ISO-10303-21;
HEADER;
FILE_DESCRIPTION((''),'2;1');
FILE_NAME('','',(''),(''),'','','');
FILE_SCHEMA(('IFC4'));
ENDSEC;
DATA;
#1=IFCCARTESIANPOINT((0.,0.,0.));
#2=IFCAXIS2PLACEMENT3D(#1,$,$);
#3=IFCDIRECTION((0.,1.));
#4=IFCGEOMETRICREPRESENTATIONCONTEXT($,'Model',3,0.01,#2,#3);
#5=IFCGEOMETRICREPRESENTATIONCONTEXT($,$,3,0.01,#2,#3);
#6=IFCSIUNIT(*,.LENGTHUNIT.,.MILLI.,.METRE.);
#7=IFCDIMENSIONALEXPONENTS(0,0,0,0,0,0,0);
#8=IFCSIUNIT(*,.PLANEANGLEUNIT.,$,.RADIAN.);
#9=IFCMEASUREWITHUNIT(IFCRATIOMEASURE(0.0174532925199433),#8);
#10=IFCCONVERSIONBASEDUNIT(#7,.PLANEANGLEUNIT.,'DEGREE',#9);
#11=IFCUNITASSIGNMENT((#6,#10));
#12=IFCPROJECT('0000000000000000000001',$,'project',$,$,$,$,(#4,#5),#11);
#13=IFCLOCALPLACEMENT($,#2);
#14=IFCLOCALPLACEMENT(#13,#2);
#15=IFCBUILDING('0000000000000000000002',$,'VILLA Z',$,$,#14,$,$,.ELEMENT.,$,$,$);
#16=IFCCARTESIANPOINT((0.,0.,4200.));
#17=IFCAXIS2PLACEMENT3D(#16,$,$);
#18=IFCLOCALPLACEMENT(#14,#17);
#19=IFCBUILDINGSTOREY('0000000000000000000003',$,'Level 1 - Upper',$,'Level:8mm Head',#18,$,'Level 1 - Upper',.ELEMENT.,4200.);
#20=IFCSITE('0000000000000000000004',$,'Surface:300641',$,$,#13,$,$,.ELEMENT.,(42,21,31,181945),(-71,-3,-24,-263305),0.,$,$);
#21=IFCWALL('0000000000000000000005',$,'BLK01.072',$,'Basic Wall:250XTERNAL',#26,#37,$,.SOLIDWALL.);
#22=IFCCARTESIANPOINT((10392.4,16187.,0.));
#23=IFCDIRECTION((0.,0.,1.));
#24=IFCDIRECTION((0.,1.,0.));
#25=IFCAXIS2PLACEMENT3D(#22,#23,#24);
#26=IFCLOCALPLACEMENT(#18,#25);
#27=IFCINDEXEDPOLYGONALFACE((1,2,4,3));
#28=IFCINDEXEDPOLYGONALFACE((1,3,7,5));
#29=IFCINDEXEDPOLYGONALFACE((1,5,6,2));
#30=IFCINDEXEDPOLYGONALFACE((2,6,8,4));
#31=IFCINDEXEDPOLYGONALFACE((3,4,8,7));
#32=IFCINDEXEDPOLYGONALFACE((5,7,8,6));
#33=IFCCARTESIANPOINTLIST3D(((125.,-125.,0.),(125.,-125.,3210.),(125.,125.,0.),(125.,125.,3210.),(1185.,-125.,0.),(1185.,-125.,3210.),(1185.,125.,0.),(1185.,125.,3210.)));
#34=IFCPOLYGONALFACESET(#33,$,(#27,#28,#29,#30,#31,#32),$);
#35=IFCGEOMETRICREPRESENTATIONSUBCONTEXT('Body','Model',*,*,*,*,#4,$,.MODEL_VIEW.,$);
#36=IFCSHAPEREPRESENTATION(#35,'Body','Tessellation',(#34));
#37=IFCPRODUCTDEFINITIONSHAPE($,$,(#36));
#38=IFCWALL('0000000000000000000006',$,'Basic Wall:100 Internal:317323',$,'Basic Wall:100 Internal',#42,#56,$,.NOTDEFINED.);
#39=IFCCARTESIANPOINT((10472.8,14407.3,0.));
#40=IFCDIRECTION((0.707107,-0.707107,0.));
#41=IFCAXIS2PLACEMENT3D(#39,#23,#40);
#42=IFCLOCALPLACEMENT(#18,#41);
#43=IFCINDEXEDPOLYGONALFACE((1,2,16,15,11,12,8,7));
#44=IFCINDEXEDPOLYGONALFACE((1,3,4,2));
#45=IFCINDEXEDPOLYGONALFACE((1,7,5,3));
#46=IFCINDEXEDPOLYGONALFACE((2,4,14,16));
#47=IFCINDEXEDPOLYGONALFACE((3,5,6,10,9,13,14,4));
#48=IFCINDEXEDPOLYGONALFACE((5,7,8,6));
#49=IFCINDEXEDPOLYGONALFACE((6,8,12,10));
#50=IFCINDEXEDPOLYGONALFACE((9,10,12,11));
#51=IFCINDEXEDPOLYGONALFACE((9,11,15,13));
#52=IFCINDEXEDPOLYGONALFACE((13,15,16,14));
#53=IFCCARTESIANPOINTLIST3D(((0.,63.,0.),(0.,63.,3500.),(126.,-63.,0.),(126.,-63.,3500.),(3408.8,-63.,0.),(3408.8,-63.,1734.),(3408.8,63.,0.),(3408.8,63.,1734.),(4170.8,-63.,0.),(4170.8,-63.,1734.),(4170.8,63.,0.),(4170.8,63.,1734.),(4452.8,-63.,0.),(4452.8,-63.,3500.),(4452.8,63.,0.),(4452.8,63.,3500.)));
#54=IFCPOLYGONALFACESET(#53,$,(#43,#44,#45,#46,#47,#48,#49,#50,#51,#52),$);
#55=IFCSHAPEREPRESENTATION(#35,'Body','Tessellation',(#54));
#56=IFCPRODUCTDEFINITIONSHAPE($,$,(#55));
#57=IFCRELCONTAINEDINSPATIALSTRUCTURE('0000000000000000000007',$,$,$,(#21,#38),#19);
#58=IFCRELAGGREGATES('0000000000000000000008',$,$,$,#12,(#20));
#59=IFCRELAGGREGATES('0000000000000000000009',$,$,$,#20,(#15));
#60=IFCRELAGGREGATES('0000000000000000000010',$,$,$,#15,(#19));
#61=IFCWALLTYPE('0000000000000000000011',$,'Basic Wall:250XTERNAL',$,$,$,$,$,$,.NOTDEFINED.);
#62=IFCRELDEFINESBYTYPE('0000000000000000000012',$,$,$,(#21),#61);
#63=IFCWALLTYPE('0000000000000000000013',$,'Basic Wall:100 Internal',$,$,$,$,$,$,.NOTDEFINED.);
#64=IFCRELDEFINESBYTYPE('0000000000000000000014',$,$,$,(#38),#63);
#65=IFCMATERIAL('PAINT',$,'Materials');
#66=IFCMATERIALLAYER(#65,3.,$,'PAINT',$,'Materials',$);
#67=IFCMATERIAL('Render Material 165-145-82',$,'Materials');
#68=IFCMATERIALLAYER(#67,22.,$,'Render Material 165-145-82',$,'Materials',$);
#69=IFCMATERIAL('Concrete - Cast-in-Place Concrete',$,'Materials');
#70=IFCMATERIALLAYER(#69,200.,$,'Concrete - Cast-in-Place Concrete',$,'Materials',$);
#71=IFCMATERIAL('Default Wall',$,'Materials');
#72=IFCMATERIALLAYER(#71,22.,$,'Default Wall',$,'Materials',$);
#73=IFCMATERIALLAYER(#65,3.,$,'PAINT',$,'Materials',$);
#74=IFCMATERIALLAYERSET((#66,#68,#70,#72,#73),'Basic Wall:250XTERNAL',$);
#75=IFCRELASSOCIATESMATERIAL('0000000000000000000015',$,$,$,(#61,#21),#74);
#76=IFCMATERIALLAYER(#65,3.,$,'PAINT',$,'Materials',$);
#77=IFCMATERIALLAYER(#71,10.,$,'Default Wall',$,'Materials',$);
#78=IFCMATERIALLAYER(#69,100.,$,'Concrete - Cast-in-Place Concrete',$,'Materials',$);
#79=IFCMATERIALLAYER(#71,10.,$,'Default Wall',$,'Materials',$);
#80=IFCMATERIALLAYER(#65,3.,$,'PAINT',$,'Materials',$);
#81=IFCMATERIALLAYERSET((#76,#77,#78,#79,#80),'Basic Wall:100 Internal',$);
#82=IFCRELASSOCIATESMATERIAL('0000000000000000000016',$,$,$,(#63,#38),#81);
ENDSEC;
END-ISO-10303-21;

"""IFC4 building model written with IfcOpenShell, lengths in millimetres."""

from ifc_helpers import new_model, entity, si_unit, converted_unit, direction, frame, frame_2d, origin, place, context, subcontext, project, spatial, polyline, rectangle, outline, extrude, clip, halfspace, bounded_halfspace, material, layer, layer_set, layer_usage, type_object, element, save


model = new_model("IFC4")

# Units and contexts
model_context = context("Model", 3, precision=0.01, world=origin(), true_north=direction((0.0, 1.0)))
context_of_model = context(None, 3, precision=0.01, world=origin(), true_north=direction((0.0, 1.0)))
body_context = subcontext(model_context, "Body", "Model", "MODEL_VIEW")
ifc_project = project(units=[si_unit("LENGTHUNIT", "METRE", prefix="MILLI"), converted_unit("PLANEANGLEUNIT", "DEGREE", entity("IfcRatioMeasure", 0.0174532925199433), si_unit("PLANEANGLEUNIT", "RADIAN"), dimensions=[0, 0, 0, 0, 0, 0, 0])], contexts=[model_context, context_of_model])

# Site, building, storey
site_placement = place(None, origin())
site = spatial("IfcSite", under=ifc_project, at=site_placement, Name="Surface:300641", CompositionType="ELEMENT", RefLatitude=(42, 21, 31, 181945), RefLongitude=(-71, -3, -24, -263305), RefElevation=0.0)
building_placement = place(site_placement, origin())
building = spatial("IfcBuilding", under=site, at=building_placement, Name="VILLA Z", CompositionType="ELEMENT")
storey_placement = place(building_placement, frame((0.0, 0.0, 4200.0)))
storey = spatial("IfcBuildingStorey", under=building, at=storey_placement, Name="Level 1 - Upper", ObjectType="Level:8mm Head", LongName="Level 1 - Upper", CompositionType="ELEMENT", Elevation=4200.0)

# Wall
ifc_material_1 = material(Name="PAINT", Category="Materials")
ifc_layer_1 = layer(ifc_material_1, 3.0, Name="PAINT", Category="Materials")
ifc_material_2 = material(Name="Render Material 165-145-82", Category="Materials")
ifc_layer_2 = layer(ifc_material_2, 22.0, Name="Render Material 165-145-82", Category="Materials")
ifc_material_3 = material(Name="Concrete - Cast-in-Place Concrete", Category="Materials")
ifc_layer_3 = layer(ifc_material_3, 200.0, Name="Concrete - Cast-in-Place Concrete", Category="Materials")
ifc_material_4 = material(Name="Default Wall", Category="Materials")
ifc_layer_4 = layer(ifc_material_4, 22.0, Name="Default Wall", Category="Materials")
ifc_layer_5 = layer(ifc_material_1, 3.0, Name="PAINT", Category="Materials")
ifc_layer_set_1 = layer_set([ifc_layer_1, ifc_layer_2, ifc_layer_3, ifc_layer_4, ifc_layer_5], Name="Basic Wall:250XTERNAL")
ifc_layer_usage_1 = layer_usage(ifc_layer_set_1, "AXIS2", "NEGATIVE", 125.0)
wall_type_1 = type_object("IfcWallType", Name="Basic Wall:250XTERNAL", PredefinedType="NOTDEFINED", material=ifc_layer_set_1)
wall_1_placement = place(storey_placement, frame((10392.4, 16187.0, 0.0), z_axis=(0.0, 0.0, 1.0), x_axis=(0.0, 1.0, 0.0)))
element("IfcWall", 1, at=wall_1_placement, inside=storey, type_object=wall_type_1, material=ifc_layer_usage_1, Name="BLK01.072", ObjectType="Basic Wall:250XTERNAL", PredefinedType="SOLIDWALL", context=body_context, shape_type="Clipping", body=[
    clip(clip(extrude(rectangle(XDim=1060.0, YDim=250.0, at=frame_2d((655.0, 0.0), x_axis=(-1.0, 0.0))), origin(), (0.0, 0.0, 1.0), 3210.0), bounded_halfspace(frame((0.0, -125.0, 3210.0), z_axis=(0.0, 0.0, -1.0), x_axis=(-1.0, 0.0, 0.0)), True, frame((0.0, -125.0, 3210.0)), polyline([(0.0, 0.0), (935.0, 0.0), (1185.0, 0.0), (1185.0, 250.0), (0.0, 250.0), (0.0, 0.0)]))), halfspace(frame((0.0, 0.0, -400.0)), True)),
])

# Shared definitions
ifc_layer_6 = layer(ifc_material_1, 3.0, Name="PAINT", Category="Materials")
ifc_layer_7 = layer(ifc_material_4, 10.0, Name="Default Wall", Category="Materials")
ifc_layer_8 = layer(ifc_material_3, 100.0, Name="Concrete - Cast-in-Place Concrete", Category="Materials")
ifc_layer_9 = layer(ifc_material_4, 10.0, Name="Default Wall", Category="Materials")
ifc_layer_10 = layer(ifc_material_1, 3.0, Name="PAINT", Category="Materials")
ifc_layer_set_2 = layer_set([ifc_layer_6, ifc_layer_7, ifc_layer_8, ifc_layer_9, ifc_layer_10], Name="Basic Wall:100 Internal")
wall_type_2 = type_object("IfcWallType", Name="Basic Wall:100 Internal", PredefinedType="NOTDEFINED", material=ifc_layer_set_2)

# Wall, opening
ifc_layer_usage_2 = layer_usage(ifc_layer_set_2, "AXIS2", "NEGATIVE", 63.0)
wall_2_placement = place(storey_placement, frame((10472.8, 14407.3, 0.0), z_axis=(0.0, 0.0, 1.0), x_axis=(0.707107, -0.707107, 0.0)))
wall_2 = element("IfcWall", 2, at=wall_2_placement, inside=storey, type_object=wall_type_2, material=ifc_layer_usage_2, Name="Basic Wall:100 Internal:317323", ObjectType="Basic Wall:100 Internal", PredefinedType="NOTDEFINED", context=body_context, shape_type="Clipping", body=[
    clip(extrude(outline(polyline([(126.0, -63.0), (1424.8, -63.0), (1674.8, -63.0), (4326.8, -63.0), (4452.8, -63.0), (4452.8, 63.0), (0.0, 63.0), (126.0, -63.0)])), origin(), (0.0, 0.0, 1.0), 3500.0), halfspace(origin(), True)),
])
opening_1_placement = place(wall_2_placement, frame((3789.8, -1968.0, -400.0), z_axis=(0.0, 0.0, 1.0), x_axis=(0.707107, 0.707107, 0.0)))
element("IfcOpeningElement", 3, at=opening_1_placement, cuts=wall_2, ObjectType="Opening", PredefinedType="OPENING", context=body_context, shape_type="SweptSolid", body=[
    extrude(rectangle(XDim=2134.0, YDim=762.0, at=frame_2d((0.0, 0.0), x_axis=(1.0, 0.0))), frame((269.4, 269.4, 1067.0), z_axis=(0.707107, 0.707107, 0.0), x_axis=(0.0, 0.0, 1.0)), (0.0, 0.0, 1.0), 3048.0),
])

save(model, "model.ifc")
